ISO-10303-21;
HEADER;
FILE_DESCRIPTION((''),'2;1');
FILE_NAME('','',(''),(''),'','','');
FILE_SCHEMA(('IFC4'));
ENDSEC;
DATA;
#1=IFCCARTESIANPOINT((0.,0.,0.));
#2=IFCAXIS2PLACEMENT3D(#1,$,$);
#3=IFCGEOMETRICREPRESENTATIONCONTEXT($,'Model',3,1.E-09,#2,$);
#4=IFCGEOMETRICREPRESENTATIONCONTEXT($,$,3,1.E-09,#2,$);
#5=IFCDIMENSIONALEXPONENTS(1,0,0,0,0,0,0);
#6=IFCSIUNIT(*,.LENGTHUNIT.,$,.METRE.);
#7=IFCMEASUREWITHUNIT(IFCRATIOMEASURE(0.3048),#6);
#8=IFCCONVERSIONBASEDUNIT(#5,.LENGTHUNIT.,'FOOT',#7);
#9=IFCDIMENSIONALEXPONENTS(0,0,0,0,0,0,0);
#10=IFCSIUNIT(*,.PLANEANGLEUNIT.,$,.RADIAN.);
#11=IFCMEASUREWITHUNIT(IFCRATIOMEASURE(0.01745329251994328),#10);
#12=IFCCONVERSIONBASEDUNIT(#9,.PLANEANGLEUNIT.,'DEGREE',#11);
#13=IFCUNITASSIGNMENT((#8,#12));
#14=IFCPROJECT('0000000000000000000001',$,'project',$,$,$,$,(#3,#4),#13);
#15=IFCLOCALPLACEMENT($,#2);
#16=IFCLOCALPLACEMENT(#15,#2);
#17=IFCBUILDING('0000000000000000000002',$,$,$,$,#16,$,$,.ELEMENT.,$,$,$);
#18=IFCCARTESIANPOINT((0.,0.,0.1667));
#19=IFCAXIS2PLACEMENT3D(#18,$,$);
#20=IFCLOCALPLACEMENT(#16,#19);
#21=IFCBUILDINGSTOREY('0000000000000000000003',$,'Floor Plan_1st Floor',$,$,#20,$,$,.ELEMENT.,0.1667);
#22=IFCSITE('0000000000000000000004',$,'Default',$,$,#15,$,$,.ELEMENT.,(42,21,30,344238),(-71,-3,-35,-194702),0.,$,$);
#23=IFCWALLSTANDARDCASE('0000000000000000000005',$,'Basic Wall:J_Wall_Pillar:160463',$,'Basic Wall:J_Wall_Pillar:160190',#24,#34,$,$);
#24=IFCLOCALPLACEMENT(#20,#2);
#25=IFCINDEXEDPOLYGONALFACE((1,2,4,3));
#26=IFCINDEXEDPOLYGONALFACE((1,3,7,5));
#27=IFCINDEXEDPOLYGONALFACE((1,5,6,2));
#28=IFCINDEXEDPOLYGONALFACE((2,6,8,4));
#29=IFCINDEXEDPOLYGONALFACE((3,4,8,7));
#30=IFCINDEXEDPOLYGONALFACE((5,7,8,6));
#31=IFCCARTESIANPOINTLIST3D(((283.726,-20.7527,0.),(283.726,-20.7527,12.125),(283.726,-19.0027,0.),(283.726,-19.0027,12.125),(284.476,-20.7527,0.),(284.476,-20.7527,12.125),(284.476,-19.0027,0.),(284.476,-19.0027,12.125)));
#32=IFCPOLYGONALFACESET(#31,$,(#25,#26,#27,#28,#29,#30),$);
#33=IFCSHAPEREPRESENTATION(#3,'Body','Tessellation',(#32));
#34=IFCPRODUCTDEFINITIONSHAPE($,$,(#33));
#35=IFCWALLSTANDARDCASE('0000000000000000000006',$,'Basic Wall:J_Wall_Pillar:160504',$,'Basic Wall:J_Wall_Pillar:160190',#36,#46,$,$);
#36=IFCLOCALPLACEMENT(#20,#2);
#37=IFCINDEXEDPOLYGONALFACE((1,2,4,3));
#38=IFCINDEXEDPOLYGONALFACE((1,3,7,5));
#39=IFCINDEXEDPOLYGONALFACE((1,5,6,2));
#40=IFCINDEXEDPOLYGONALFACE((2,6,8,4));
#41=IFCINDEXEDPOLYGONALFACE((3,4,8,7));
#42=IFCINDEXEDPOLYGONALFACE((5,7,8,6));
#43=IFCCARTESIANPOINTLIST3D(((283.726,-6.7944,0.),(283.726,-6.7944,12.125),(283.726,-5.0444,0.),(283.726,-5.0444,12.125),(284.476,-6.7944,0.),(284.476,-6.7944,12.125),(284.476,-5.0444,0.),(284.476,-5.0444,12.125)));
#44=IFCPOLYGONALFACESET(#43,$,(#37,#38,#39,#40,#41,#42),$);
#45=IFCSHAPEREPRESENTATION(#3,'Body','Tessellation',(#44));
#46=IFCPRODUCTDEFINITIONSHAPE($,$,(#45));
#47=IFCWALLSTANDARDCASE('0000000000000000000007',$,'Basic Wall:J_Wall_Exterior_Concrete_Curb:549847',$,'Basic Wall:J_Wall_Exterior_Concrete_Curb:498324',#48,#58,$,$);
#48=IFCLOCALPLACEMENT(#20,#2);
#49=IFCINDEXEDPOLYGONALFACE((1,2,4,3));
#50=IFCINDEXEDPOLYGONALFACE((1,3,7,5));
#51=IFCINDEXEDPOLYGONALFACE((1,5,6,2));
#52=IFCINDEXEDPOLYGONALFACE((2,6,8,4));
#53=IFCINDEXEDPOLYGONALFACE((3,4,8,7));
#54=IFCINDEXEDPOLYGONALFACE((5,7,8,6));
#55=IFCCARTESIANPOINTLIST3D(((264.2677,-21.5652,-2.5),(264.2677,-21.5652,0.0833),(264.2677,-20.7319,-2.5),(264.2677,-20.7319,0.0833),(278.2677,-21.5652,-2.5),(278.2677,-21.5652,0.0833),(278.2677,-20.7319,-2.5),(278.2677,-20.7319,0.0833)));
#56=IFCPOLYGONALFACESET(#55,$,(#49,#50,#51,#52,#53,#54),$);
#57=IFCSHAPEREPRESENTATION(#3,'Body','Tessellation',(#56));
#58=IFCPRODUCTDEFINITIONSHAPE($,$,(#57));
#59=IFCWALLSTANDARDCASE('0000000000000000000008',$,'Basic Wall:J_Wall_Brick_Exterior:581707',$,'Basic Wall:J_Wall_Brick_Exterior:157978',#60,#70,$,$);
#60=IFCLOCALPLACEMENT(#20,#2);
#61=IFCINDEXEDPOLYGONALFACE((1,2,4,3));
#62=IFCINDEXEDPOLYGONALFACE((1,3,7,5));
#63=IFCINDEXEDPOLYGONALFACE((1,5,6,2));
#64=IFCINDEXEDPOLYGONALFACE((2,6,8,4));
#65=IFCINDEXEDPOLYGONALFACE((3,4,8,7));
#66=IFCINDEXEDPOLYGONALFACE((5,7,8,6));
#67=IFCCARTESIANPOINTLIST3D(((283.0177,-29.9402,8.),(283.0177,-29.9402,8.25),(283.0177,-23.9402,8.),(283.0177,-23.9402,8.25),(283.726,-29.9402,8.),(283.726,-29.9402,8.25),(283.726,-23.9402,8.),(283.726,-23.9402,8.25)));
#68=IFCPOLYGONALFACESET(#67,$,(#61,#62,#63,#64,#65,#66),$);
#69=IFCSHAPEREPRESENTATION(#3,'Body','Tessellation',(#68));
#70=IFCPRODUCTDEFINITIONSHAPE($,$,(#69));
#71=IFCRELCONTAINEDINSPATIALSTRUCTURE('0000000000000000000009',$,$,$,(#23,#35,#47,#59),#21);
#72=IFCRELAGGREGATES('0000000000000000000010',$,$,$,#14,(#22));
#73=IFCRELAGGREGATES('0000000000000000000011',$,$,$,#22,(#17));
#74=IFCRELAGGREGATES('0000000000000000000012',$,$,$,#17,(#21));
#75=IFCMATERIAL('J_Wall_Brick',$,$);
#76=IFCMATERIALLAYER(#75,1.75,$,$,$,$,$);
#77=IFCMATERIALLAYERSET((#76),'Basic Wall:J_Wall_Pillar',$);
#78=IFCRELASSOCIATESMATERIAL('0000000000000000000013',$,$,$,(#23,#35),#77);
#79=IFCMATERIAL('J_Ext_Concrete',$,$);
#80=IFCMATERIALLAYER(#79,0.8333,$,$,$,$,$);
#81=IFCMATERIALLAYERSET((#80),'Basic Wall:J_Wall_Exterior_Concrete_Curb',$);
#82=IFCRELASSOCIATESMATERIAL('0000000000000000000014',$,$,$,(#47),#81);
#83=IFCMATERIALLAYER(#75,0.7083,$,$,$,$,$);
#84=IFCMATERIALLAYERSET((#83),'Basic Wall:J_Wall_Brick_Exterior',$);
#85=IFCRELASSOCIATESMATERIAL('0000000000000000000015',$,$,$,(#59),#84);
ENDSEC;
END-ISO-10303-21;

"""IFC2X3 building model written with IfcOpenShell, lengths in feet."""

from ifc_helpers import new_model, entity, si_unit, converted_unit, frame, frame_2d, origin, place, context, project, spatial, rectangle, extrude, clip, halfspace, material, layer, layer_set, layer_usage, element, save


model = new_model("IFC2X3")

# Units and contexts
model_context = context("Model", 3, precision=1e-09, world=origin())
context_of_model = context(None, 3, precision=1e-09, world=origin())
ifc_project = project(units=[converted_unit("LENGTHUNIT", "FOOT", entity("IfcRatioMeasure", 0.3048), si_unit("LENGTHUNIT", "METRE"), dimensions=[1, 0, 0, 0, 0, 0, 0]), converted_unit("PLANEANGLEUNIT", "DEGREE", entity("IfcRatioMeasure", 0.01745329251994328), si_unit("PLANEANGLEUNIT", "RADIAN"), dimensions=[0, 0, 0, 0, 0, 0, 0])], contexts=[model_context, context_of_model])

# Site, building, storey
site_placement = place(None, origin())
site = spatial("IfcSite", under=ifc_project, at=site_placement, Name="Default", CompositionType="ELEMENT", RefLatitude=(42, 21, 30, 344238), RefLongitude=(-71, -3, -35, -194702), RefElevation=0.0)
building_placement = place(site_placement, origin())
building = spatial("IfcBuilding", under=site, at=building_placement, CompositionType="ELEMENT")
storey_placement = place(building_placement, frame((0.0, 0.0, 0.1667)))
storey = spatial("IfcBuildingStorey", under=building, at=storey_placement, Name="Floor Plan_1st Floor", CompositionType="ELEMENT", Elevation=0.1667)

# Walls
ifc_material_1 = material(Name="J_Wall_Brick")
ifc_layer_1 = layer(ifc_material_1, 1.75)
ifc_layer_set_1 = layer_set([ifc_layer_1], Name="Basic Wall:J_Wall_Pillar")
ifc_layer_usage_1 = layer_usage(ifc_layer_set_1, "AXIS2", "NEGATIVE", 0.875)
wall_1_placement = place(storey_placement, frame((283.726, -19.8777, 0.0)))
element("IfcWallStandardCase", 1, at=wall_1_placement, inside=storey, material=ifc_layer_usage_1, Name="Basic Wall:J_Wall_Pillar:160463", ObjectType="Basic Wall:J_Wall_Pillar:160190", context=model_context, shape_type="Clipping", body=[
    clip(extrude(rectangle(XDim=0.75, YDim=1.75, at=frame_2d((0.375, 0.0), x_axis=(-1.0, 0.0))), origin(), (0.0, 0.0, 1.0), 12.125), halfspace(origin(), True)),
])
ifc_layer_usage_2 = layer_usage(ifc_layer_set_1, "AXIS2", "NEGATIVE", 0.875)
wall_2_placement = place(storey_placement, frame((283.726, -5.9194, 0.0)))
element("IfcWallStandardCase", 2, at=wall_2_placement, inside=storey, material=ifc_layer_usage_2, Name="Basic Wall:J_Wall_Pillar:160504", ObjectType="Basic Wall:J_Wall_Pillar:160190", context=model_context, shape_type="Clipping", body=[
    clip(extrude(rectangle(XDim=0.75, YDim=1.75, at=frame_2d((0.375, 0.0), x_axis=(-1.0, 0.0))), origin(), (0.0, 0.0, 1.0), 12.125), halfspace(origin(), True)),
])
ifc_material_2 = material(Name="J_Ext_Concrete")
ifc_layer_2 = layer(ifc_material_2, 0.8333)
ifc_layer_set_2 = layer_set([ifc_layer_2], Name="Basic Wall:J_Wall_Exterior_Concrete_Curb")
ifc_layer_usage_3 = layer_usage(ifc_layer_set_2, "AXIS2", "POSITIVE", -0.4167)
wall_3_placement = place(storey_placement, frame((264.2677, -21.1486, -2.5)))
element("IfcWallStandardCase", 3, at=wall_3_placement, inside=storey, material=ifc_layer_usage_3, Name="Basic Wall:J_Wall_Exterior_Concrete_Curb:549847", ObjectType="Basic Wall:J_Wall_Exterior_Concrete_Curb:498324", context=model_context, shape_type="SweptSolid", body=[
    extrude(rectangle(XDim=14.0, YDim=0.8333, at=frame_2d((7.0, 0.0), x_axis=(-1.0, 0.0))), origin(), (0.0, 0.0, 1.0), 2.5833),
])

# Wall, opening
ifc_layer_3 = layer(ifc_material_1, 0.7083)
ifc_layer_set_3 = layer_set([ifc_layer_3], Name="Basic Wall:J_Wall_Brick_Exterior")
ifc_layer_usage_4 = layer_usage(ifc_layer_set_3, "AXIS2", "POSITIVE", -0.3542)
wall_4_placement = place(storey_placement, frame((283.3719, -23.9402, 0.0), z_axis=(0.0, 0.0, 1.0), x_axis=(0.0, -1.0, 0.0)))
wall_4 = element("IfcWallStandardCase", 4, at=wall_4_placement, inside=storey, material=ifc_layer_usage_4, Name="Basic Wall:J_Wall_Brick_Exterior:581707", ObjectType="Basic Wall:J_Wall_Brick_Exterior:157978", context=model_context, shape_type="SweptSolid", body=[
    extrude(rectangle(XDim=6.0, YDim=0.7083, at=frame_2d((3.0, 0.0), x_axis=(-1.0, 0.0))), origin(), (0.0, 0.0, 1.0), 8.25),
])
opening_placement = place(wall_4_placement, frame((6.0, 0.3542, 0.0)))
element("IfcOpeningElement", 5, at=opening_placement, cuts=wall_4, ObjectType="Opening", context=model_context, shape_type="SweptSolid", body=[
    extrude(rectangle(XDim=8.0, YDim=6.0, at=frame_2d((4.0, 3.0), x_axis=(1.0, 0.0))), frame((0.0, 0.0, 0.0), z_axis=(0.0, -1.0, 0.0), x_axis=(0.0, 0.0, 1.0)), (0.0, 0.0, 1.0), 0.7083),
])

save(model, "model.ifc")
